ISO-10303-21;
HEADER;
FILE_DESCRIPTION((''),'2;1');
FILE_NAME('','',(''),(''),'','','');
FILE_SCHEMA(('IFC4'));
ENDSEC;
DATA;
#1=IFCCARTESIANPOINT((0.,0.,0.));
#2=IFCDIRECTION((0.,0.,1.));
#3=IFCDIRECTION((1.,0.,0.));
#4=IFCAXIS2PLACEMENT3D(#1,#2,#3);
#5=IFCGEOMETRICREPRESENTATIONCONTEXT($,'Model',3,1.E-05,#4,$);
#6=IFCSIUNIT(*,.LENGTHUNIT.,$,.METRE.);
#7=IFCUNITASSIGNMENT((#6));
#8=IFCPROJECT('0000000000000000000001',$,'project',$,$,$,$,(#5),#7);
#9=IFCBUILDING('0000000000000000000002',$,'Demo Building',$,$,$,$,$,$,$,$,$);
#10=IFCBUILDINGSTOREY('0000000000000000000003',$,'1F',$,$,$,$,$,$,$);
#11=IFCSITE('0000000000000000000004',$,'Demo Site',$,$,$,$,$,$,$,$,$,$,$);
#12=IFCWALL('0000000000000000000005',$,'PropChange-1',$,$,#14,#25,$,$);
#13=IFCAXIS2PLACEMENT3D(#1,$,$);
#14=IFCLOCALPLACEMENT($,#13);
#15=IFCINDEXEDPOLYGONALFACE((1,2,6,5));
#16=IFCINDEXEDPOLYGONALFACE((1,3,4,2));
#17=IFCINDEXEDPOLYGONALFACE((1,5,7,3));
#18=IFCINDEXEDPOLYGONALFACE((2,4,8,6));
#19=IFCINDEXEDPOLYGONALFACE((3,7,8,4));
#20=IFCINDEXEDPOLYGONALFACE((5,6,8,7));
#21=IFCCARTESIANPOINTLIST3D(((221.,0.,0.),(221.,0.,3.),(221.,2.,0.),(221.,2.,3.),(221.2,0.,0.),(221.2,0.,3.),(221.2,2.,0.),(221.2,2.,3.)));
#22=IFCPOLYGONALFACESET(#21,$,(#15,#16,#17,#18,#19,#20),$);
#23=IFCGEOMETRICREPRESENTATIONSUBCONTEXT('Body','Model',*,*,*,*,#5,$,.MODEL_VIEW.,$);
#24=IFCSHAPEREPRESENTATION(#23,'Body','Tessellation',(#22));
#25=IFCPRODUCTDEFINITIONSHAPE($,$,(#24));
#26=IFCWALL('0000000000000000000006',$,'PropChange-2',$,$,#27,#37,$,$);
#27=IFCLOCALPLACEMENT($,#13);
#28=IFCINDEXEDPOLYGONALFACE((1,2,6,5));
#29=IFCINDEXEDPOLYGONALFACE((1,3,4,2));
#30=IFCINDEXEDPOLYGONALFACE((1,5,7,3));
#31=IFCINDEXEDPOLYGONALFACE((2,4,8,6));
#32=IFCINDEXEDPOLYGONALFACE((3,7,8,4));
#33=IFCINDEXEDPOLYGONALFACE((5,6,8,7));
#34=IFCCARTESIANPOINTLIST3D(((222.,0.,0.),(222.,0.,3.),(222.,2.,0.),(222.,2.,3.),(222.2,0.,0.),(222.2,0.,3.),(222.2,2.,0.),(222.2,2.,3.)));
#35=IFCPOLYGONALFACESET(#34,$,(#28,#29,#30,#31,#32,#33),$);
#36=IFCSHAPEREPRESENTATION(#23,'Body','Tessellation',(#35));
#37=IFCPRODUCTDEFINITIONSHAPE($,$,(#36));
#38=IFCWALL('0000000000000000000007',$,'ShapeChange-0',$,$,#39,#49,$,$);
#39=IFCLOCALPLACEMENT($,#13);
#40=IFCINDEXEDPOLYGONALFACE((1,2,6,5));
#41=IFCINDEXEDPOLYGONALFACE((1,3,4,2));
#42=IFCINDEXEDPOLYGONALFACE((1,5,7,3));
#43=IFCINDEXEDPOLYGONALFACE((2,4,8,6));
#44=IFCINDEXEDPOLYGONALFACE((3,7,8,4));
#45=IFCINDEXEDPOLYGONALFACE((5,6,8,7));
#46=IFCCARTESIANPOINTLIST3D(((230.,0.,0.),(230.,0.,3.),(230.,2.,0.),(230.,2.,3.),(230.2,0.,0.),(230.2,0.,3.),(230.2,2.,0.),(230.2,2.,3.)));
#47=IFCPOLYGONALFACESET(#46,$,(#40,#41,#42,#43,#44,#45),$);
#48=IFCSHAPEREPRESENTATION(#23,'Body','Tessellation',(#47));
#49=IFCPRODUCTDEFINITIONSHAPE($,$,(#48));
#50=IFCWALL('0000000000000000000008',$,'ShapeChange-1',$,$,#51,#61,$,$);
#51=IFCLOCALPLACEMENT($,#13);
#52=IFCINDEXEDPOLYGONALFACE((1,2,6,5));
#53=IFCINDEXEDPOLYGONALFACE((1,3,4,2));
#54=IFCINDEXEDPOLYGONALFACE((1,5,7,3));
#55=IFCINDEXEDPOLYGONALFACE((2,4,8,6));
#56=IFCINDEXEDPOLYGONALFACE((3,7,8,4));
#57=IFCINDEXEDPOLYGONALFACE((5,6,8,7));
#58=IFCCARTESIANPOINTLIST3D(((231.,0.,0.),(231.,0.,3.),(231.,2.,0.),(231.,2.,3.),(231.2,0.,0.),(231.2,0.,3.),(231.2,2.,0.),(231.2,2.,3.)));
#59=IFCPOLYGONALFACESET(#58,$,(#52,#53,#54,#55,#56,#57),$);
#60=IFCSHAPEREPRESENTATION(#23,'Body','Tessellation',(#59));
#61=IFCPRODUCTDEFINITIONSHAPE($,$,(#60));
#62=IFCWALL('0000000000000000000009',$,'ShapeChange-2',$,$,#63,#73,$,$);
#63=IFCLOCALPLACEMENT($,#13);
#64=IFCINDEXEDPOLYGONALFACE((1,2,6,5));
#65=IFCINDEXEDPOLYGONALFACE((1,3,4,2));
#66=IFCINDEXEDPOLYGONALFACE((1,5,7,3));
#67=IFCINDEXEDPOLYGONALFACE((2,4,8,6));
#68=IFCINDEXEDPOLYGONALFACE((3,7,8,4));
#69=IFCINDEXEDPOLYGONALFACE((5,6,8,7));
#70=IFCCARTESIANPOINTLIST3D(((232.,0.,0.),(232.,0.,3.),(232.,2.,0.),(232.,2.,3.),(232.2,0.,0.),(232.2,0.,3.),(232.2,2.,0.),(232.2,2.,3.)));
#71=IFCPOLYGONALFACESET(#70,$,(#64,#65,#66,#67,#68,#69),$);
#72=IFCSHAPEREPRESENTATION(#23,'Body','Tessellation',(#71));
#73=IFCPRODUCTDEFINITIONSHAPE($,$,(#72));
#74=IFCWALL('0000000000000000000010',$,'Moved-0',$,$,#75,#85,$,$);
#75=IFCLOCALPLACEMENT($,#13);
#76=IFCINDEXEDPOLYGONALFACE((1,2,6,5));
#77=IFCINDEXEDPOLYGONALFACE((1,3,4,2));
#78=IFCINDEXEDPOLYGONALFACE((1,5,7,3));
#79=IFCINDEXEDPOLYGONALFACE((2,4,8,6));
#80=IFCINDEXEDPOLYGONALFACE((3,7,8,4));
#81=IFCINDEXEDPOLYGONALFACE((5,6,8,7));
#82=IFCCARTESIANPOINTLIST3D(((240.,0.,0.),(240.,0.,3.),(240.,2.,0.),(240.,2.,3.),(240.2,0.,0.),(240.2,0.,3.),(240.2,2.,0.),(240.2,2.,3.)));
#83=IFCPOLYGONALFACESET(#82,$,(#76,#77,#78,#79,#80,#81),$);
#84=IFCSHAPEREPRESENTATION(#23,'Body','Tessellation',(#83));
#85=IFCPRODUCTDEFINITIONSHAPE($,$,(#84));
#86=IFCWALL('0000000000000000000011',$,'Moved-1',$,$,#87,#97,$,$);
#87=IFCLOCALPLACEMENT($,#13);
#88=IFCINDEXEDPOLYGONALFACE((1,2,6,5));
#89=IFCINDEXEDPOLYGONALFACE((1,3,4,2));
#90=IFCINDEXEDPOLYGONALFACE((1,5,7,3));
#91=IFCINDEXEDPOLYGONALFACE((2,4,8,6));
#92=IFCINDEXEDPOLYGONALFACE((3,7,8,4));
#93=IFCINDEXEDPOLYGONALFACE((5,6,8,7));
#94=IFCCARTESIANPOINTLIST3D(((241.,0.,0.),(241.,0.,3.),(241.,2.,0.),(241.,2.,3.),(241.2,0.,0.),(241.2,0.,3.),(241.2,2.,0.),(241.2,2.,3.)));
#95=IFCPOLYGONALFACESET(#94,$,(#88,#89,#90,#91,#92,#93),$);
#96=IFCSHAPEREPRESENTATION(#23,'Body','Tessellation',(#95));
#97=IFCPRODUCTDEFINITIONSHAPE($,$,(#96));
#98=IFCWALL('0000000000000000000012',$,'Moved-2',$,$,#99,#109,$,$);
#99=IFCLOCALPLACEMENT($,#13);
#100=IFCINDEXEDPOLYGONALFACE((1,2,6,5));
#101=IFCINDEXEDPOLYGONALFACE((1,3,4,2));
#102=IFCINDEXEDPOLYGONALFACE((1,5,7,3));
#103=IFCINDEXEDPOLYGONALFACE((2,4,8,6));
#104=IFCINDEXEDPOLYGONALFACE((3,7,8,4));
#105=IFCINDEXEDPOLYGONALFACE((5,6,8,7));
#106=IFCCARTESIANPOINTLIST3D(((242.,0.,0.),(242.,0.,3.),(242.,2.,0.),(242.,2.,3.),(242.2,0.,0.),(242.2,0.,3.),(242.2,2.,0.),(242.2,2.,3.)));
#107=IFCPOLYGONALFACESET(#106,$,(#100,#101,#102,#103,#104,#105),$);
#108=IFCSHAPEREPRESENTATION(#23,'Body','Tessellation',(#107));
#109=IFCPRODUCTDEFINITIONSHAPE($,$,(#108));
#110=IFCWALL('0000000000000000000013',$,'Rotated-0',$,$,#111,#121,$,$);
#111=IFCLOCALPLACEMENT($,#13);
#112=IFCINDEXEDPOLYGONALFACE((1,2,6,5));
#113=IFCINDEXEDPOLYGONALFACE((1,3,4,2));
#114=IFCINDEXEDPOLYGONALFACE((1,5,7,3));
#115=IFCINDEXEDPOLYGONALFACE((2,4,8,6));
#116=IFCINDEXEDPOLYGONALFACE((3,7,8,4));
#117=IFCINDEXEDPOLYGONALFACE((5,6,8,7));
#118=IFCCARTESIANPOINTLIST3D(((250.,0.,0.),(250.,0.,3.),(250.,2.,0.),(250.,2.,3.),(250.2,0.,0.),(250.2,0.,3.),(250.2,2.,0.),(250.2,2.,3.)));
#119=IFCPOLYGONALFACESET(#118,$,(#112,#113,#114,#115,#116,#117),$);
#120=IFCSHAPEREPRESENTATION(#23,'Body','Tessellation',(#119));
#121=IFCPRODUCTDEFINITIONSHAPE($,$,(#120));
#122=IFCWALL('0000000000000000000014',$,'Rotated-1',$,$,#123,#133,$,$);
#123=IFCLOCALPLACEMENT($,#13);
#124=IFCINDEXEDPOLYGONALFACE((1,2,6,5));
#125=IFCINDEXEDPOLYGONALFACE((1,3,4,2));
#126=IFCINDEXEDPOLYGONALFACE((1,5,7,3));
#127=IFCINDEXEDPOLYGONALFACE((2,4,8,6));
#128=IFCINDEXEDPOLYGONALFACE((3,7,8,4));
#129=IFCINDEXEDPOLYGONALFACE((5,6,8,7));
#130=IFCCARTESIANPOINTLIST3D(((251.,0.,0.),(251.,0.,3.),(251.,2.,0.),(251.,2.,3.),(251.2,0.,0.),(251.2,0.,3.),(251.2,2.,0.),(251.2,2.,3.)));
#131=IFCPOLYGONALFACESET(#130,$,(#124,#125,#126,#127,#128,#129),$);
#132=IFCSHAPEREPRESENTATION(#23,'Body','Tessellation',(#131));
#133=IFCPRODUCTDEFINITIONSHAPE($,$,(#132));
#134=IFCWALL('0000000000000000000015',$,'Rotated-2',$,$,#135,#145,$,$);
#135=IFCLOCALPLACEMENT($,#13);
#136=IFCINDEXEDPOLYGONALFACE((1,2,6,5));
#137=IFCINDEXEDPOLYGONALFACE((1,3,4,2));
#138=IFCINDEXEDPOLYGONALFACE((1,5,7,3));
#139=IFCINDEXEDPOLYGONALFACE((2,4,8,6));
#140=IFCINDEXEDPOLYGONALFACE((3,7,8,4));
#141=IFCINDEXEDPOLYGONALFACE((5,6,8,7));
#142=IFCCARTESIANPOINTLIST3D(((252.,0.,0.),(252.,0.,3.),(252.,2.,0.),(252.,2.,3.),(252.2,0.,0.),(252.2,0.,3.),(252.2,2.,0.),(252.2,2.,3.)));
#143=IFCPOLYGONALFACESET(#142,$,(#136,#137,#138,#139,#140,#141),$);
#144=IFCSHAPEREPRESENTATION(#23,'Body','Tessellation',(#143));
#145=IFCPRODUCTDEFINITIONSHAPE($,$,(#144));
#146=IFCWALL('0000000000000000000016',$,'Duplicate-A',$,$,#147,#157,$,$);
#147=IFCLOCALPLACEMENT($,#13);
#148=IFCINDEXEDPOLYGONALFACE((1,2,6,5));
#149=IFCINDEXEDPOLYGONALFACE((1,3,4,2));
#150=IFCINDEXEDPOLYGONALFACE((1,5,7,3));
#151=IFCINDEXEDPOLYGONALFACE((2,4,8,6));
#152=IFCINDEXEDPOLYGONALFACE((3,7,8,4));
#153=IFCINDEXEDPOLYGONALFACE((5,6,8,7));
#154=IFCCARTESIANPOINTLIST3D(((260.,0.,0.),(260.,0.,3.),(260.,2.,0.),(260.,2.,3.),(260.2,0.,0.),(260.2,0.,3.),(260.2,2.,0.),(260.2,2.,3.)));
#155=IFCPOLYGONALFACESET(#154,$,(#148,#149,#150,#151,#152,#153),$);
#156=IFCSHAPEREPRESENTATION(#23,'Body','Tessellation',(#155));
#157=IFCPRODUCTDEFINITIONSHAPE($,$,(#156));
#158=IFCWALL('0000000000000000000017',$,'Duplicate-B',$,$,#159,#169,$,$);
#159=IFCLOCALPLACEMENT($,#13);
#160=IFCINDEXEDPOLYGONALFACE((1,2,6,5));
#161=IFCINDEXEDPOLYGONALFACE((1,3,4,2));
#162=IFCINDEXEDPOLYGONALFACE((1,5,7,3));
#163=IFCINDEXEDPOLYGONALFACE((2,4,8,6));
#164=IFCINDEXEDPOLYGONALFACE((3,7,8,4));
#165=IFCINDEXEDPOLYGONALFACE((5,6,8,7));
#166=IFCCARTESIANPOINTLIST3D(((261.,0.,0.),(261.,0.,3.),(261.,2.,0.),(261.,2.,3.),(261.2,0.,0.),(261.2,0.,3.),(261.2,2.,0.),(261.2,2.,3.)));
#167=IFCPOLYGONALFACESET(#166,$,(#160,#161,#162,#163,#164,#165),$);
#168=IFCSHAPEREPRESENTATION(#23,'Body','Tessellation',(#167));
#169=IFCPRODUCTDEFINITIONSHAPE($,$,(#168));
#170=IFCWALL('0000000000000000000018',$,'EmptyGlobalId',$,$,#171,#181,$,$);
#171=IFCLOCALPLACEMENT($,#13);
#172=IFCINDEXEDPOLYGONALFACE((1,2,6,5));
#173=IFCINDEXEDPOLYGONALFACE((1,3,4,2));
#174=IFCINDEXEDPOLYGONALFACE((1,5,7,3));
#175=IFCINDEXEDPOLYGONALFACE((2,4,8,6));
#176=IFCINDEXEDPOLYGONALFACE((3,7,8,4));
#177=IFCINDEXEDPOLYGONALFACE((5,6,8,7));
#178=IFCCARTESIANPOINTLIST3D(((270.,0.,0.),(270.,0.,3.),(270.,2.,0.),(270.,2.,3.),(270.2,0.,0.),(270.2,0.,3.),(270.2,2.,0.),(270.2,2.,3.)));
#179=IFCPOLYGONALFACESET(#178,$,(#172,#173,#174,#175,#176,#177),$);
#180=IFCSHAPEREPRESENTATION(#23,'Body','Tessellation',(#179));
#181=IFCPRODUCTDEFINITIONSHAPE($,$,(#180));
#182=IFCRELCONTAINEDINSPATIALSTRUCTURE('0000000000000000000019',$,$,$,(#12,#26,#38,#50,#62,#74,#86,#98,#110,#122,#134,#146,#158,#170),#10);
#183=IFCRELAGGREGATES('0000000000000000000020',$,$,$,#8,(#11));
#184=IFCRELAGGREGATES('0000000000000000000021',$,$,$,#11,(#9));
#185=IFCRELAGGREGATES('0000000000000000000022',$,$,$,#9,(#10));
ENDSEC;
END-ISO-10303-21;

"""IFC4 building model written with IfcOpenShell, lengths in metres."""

from ifc_helpers import new_model, entity, si_unit, frame, origin_with_axes, place, context, subcontext, project, spatial, element, save


model = new_model("IFC4")

# Units and contexts
model_context = context("Model", 3, precision=1e-05, world=origin_with_axes())
body_context = subcontext(model_context, "Body", "Model", "MODEL_VIEW")
ifc_project = project(units=[si_unit("LENGTHUNIT", "METRE")], contexts=[model_context])

# Site, building, storey
site = spatial("IfcSite", under=ifc_project, Name="Demo Site")
building = spatial("IfcBuilding", under=site, Name="Demo Building")
storey = spatial("IfcBuildingStorey", under=building, Name="1F")

# Walls
for number, where, z_axis, x_axis, name in (
    (1, (221.0, 0.0, 0.0), (0.0, 0.0, 1.0), (1.0, 0.0, 0.0), "PropChange-1"),
    (2, (222.0, 0.0, 0.0), (0.0, 0.0, 1.0), (1.0, 0.0, 0.0), "PropChange-2"),
    (3, (230.0, 0.0, 0.0), (0.0, 0.0, 1.0), (1.0, 0.0, 0.0), "ShapeChange-0"),
    (4, (231.0, 0.0, 0.0), (0.0, 0.0, 1.0), (1.0, 0.0, 0.0), "ShapeChange-1"),
    (5, (232.0, 0.0, 0.0), (0.0, 0.0, 1.0), (1.0, 0.0, 0.0), "ShapeChange-2"),
    (6, (240.0, 0.0, 0.0), (0.0, 0.0, 1.0), (1.0, 0.0, 0.0), "Moved-0"),
    (7, (241.0, 0.0, 0.0), (0.0, 0.0, 1.0), (1.0, 0.0, 0.0), "Moved-1"),
    (8, (242.0, 0.0, 0.0), (0.0, 0.0, 1.0), (1.0, 0.0, 0.0), "Moved-2"),
    (9, (250.0, 0.0, 0.0), (0.0, 0.0, 1.0), (1.0, 0.0, 0.0), "Rotated-0"),
    (10, (251.0, 0.0, 0.0), (0.0, 0.0, 1.0), (1.0, 0.0, 0.0), "Rotated-1"),
    (11, (252.0, 0.0, 0.0), (0.0, 0.0, 1.0), (1.0, 0.0, 0.0), "Rotated-2"),
    (12, (260.0, 0.0, 0.0), (0.0, 0.0, 1.0), (1.0, 0.0, 0.0), "Duplicate-A"),
    (13, (261.0, 0.0, 0.0), (0.0, 0.0, 1.0), (1.0, 0.0, 0.0), "Duplicate-B"),
    (14, (270.0, 0.0, 0.0), (0.0, 0.0, 1.0), (1.0, 0.0, 0.0), "EmptyGlobalId"),
):
    element("IfcWall", number, at=place(None, frame(where, z_axis=z_axis, x_axis=x_axis)), inside=storey, Name=name, context=body_context, shape_type="CSG", body=[
        entity("IfcBlock", entity("IfcAxis2Placement3D", entity("IfcCartesianPoint", [0.0, 0.0, 0.0]), entity("IfcDirection", [0.0, 0.0, 1.0]), entity("IfcDirection", [1.0, 0.0, 0.0])), 0.2, 2.0, 3.0),
    ])

save(model, "model.ifc")
